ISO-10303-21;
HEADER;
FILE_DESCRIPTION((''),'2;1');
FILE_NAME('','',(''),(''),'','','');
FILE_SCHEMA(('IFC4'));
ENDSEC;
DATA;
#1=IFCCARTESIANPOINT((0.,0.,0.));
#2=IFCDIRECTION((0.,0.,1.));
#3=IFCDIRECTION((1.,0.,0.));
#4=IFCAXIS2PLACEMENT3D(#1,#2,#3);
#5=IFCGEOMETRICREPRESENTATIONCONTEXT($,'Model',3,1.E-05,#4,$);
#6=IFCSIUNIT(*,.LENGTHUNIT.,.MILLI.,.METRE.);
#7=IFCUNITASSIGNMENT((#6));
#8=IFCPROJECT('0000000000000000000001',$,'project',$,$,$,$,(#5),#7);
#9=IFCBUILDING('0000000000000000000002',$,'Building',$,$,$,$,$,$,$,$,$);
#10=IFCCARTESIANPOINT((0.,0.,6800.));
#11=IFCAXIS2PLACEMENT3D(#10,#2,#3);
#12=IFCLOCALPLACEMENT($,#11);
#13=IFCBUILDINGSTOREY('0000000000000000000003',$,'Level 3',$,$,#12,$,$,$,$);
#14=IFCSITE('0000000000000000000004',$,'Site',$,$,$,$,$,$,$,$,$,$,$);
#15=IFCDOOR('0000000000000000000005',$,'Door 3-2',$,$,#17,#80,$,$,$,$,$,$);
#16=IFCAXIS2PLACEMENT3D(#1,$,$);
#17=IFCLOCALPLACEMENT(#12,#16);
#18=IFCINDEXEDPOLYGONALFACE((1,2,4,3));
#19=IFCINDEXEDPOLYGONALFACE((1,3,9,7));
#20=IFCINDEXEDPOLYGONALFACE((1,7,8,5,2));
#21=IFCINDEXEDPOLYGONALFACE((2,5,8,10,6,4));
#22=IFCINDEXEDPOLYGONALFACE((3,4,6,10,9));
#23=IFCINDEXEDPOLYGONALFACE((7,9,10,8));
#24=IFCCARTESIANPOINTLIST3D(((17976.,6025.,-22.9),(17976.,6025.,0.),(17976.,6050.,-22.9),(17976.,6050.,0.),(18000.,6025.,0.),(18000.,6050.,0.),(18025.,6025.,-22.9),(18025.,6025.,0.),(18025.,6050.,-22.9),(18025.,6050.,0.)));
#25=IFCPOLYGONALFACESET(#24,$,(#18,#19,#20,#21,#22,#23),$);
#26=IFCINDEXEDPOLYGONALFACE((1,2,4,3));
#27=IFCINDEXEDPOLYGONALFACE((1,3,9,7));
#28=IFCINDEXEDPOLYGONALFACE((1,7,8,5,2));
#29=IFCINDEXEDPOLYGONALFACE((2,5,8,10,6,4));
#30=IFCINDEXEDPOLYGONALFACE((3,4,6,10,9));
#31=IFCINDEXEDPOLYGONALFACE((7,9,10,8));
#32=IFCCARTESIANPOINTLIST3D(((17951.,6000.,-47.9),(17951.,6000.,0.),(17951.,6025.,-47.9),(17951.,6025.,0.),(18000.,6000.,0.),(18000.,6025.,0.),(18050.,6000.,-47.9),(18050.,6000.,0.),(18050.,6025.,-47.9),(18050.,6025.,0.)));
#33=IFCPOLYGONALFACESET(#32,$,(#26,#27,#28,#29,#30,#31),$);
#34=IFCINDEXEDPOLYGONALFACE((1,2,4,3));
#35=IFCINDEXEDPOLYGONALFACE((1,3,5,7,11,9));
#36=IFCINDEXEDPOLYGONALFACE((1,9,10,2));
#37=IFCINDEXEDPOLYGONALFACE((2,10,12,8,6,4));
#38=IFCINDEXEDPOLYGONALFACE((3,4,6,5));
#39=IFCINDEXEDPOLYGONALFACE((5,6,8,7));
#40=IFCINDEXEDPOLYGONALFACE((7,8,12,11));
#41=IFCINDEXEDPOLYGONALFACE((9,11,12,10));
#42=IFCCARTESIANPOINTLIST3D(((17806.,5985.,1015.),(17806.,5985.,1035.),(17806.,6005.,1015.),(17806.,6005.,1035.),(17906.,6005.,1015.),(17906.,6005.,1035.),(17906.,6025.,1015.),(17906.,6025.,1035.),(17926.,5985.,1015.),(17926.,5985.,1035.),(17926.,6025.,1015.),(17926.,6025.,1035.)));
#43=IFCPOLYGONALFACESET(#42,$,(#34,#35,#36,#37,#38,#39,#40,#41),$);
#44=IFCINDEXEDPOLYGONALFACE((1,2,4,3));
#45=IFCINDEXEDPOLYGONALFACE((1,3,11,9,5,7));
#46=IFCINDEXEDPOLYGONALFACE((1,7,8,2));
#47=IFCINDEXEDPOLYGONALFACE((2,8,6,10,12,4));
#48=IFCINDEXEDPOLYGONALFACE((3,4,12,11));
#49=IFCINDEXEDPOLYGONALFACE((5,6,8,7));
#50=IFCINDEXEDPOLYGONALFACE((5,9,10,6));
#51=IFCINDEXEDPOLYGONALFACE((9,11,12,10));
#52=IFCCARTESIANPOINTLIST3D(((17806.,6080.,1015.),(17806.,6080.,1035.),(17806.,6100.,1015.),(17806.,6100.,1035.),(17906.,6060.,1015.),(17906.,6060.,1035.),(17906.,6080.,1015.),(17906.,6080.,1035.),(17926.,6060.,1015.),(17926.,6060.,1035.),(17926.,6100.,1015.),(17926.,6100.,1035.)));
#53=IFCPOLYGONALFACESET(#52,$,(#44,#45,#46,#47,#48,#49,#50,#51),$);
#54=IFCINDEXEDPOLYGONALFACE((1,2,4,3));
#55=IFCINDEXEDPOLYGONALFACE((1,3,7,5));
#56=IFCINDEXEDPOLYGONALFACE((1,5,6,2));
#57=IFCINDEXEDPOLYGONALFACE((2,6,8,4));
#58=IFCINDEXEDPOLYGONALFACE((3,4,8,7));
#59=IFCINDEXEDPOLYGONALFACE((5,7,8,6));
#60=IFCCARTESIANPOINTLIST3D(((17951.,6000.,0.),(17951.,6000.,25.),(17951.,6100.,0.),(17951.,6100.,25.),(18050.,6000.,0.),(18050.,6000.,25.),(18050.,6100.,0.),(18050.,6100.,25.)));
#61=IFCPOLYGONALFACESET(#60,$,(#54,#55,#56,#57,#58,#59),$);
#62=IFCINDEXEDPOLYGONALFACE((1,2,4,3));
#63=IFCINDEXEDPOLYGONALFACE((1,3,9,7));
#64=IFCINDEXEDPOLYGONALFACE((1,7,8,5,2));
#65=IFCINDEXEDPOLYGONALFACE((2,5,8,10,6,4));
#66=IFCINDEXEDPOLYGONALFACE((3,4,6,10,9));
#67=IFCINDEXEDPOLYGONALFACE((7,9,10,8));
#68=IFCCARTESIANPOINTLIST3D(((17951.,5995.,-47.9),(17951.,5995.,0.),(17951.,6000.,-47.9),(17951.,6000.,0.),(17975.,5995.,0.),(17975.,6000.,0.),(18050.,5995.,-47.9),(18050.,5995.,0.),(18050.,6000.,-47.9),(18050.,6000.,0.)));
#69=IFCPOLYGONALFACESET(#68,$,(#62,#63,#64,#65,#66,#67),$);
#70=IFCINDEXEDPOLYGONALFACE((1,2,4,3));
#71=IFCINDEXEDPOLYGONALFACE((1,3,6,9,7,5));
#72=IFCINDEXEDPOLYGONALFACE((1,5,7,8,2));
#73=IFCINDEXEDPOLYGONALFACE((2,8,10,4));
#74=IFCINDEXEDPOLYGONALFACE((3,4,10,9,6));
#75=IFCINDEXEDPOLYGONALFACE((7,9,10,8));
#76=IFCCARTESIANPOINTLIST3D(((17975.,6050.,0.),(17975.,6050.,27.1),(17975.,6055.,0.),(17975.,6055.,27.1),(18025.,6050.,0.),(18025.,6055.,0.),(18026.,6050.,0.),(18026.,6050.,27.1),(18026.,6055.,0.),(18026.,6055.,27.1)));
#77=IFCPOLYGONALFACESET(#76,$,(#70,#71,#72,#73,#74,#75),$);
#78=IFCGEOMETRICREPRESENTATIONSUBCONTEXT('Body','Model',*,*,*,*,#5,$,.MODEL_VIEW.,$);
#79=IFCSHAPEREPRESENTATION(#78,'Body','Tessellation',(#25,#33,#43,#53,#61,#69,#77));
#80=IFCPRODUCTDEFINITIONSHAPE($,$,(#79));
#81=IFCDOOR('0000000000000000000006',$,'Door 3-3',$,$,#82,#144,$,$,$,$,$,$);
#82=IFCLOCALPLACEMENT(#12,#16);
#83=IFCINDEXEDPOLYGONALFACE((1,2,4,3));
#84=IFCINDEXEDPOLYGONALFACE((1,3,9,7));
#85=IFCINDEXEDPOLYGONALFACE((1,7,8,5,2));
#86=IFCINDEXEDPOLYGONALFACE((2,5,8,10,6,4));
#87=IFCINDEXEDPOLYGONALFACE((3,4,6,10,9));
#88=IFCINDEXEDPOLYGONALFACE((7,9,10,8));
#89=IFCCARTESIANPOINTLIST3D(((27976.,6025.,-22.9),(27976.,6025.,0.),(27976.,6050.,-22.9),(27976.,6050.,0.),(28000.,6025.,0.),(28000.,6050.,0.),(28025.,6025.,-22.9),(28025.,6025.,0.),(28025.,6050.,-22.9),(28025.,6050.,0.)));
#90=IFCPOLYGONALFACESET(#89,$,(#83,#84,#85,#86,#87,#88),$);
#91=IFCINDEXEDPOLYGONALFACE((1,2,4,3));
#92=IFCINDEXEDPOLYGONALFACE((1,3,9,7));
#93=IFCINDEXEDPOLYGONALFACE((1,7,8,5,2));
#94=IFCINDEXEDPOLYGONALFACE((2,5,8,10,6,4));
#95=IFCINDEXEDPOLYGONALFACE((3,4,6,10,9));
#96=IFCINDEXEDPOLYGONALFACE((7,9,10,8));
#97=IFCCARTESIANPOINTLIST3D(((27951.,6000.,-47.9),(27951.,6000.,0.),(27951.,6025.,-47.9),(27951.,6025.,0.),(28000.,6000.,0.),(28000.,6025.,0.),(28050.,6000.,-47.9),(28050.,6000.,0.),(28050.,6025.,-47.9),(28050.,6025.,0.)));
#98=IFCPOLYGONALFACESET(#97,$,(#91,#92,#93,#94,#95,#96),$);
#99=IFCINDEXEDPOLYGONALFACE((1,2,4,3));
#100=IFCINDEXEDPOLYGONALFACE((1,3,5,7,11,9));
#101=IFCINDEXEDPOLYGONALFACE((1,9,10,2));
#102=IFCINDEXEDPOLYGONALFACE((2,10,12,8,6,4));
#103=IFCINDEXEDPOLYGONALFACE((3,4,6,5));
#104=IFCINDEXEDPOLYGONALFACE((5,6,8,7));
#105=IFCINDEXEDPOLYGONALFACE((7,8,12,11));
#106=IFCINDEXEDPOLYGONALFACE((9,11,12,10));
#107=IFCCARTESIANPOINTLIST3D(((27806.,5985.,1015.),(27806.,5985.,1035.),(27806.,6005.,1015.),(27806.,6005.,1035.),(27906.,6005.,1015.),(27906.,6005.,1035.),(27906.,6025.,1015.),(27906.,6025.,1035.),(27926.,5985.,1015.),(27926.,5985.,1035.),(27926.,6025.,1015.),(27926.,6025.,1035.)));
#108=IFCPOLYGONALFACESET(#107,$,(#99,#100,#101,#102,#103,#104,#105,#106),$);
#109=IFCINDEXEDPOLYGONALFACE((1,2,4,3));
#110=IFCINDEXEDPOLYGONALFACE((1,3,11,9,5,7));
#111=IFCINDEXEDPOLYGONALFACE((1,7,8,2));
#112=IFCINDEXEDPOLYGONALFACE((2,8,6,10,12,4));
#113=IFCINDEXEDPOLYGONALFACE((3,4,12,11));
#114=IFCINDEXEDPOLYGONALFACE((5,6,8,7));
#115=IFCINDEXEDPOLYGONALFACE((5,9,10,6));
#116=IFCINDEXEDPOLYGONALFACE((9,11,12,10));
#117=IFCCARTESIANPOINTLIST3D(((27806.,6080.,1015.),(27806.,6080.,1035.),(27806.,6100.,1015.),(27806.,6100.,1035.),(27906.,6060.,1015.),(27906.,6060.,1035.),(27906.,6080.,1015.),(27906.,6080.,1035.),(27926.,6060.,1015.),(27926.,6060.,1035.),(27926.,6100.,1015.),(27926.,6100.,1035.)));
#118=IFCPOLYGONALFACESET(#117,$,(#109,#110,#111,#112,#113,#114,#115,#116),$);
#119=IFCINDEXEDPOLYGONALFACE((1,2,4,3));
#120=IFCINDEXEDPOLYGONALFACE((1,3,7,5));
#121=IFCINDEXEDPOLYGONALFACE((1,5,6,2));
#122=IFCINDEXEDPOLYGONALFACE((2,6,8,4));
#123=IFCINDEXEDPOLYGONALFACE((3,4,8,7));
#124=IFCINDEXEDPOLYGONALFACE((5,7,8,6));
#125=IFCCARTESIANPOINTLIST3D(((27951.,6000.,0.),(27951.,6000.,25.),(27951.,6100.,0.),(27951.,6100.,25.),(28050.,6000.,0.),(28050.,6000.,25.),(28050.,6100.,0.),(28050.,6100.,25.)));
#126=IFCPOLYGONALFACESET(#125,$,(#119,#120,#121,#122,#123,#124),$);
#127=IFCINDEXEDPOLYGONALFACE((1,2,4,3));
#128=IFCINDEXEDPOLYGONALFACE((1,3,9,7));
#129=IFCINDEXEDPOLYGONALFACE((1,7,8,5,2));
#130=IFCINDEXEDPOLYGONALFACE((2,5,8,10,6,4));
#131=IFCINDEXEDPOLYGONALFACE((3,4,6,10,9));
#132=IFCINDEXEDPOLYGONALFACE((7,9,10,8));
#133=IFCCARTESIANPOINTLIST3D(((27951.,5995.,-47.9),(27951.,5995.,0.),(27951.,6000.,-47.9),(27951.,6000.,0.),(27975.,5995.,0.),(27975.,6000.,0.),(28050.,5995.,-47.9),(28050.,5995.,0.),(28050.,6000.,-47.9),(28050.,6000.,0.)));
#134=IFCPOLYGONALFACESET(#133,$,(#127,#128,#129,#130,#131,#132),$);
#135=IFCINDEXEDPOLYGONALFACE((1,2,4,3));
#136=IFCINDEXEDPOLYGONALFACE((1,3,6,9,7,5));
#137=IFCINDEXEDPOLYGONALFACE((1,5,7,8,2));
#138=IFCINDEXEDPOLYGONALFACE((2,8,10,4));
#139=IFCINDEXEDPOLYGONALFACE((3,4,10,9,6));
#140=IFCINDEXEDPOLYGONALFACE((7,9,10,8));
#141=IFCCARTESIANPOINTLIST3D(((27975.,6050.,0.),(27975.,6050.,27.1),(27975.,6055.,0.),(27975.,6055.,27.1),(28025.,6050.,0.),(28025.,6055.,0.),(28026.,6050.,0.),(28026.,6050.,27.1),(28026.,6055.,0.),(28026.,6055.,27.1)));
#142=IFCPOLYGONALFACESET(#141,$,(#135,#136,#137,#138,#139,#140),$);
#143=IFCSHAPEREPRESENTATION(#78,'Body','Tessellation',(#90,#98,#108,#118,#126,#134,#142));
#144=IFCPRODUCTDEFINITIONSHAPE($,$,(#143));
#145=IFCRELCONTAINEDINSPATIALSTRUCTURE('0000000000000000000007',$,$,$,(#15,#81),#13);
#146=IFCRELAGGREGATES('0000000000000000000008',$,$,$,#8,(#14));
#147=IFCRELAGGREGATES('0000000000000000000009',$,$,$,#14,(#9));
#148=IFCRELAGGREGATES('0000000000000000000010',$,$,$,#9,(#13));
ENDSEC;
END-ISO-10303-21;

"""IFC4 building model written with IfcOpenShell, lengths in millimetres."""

from ifc_helpers import new_model, si_unit, frame, origin_with_axes, place, context, subcontext, project, spatial, line, indexed_curve, outline, extrude, element, save


model = new_model("IFC4")

# Units and contexts
model_context = context("Model", 3, precision=1e-05, world=origin_with_axes())
body_context = subcontext(model_context, "Body", "Model", "MODEL_VIEW")
ifc_project = project(units=[si_unit("LENGTHUNIT", "METRE", prefix="MILLI")], contexts=[model_context])

# Site, building, storey
site = spatial("IfcSite", under=ifc_project, Name="Site")
building = spatial("IfcBuilding", under=site, Name="Building")
storey_placement = place(None, frame((0.0, 0.0, 6800.0), z_axis=(0.0, 0.0, 1.0), x_axis=(1.0, 0.0, 0.0)))
storey = spatial("IfcBuildingStorey", under=building, at=storey_placement, Name="Level 3")

# Doors
door_1_placement = place(storey_placement, frame((18000.0, 6000.0, 0.0), z_axis=(0.0, 0.0, 1.0), x_axis=(1.0, 0.0, 0.0)))
element("IfcDoor", 1, at=door_1_placement, inside=storey, Name="Door 3-2", context=body_context, shape_type="SweptSolid", body=[
    extrude(outline(indexed_curve([(0.0, 0.0), (0.0, 2.1), (1.0, 2.1), (1.0, 0.0), (-24.0, 0.0), (-24.0, -22.9), (25.0, -22.9), (25.0, 0.0)], segments=[line(1, 2, 3, 4, 5, 6, 7, 8, 1)])), frame((0.0, 25.0, 0.0), z_axis=(0.0, -1.0, 0.0), x_axis=(1.0, 0.0, 0.0)), (0.0, 0.0, -1.0), 25.0),
    extrude(outline(indexed_curve([(0.0, 0.0), (0.0, 2.1), (1.0, 2.1), (1.0, 0.0), (-49.0, 0.0), (-49.0, -47.9), (50.0, -47.9), (50.0, 0.0)], segments=[line(1, 2, 3, 4, 5, 6, 7, 8, 1)])), frame((0.0, 0.0, 0.0), z_axis=(0.0, -1.0, 0.0), x_axis=(1.0, 0.0, 0.0)), (0.0, 0.0, -1.0), 25.0),
    extrude(outline(indexed_curve([(0.0, 0.0), (-49.0, 0.0), (-49.0, 35.0), (0.0, 35.0)], segments=[line(1, 2, 3, 4, 1)])), frame((25.0, 25.0, 25.0), z_axis=(0.0, 0.0, 1.0), x_axis=(1.0, 0.0, 0.0)), (0.0, 0.0, 1.0), -47.9),
    extrude(outline(indexed_curve([(0.0, 0.0), (0.0, -40.0), (-120.0, -40.0), (-120.0, -20.0), (-20.0, -20.0), (-20.0, 0.0)], segments=[line(1, 2, 3, 4, 5, 6, 1)])), frame((-74.0, 25.0, 1015.0), z_axis=(0.0, 0.0, 1.0), x_axis=(1.0, 0.0, 0.0)), (0.0, 0.0, 1.0), 20.0),
    extrude(outline(indexed_curve([(0.0, 0.0), (0.0, 40.0), (-120.0, 40.0), (-120.0, 20.0), (-20.0, 20.0), (-20.0, 0.0)], segments=[line(1, 2, 3, 4, 5, 6, 1)])), frame((-74.0, 60.0, 1015.0), z_axis=(0.0, 0.0, 1.0), x_axis=(1.0, 0.0, 0.0)), (0.0, 0.0, 1.0), 20.0),
    extrude(outline(indexed_curve([(0.0, 0.0), (-99.0, 0.0), (-99.0, 100.0), (0.0, 100.0)], segments=[line(1, 2, 3, 4, 1)])), frame((50.0, 0.0, 0.0), z_axis=(0.0, 0.0, 1.0), x_axis=(1.0, 0.0, 0.0)), (0.0, 0.0, 1.0), 25.0),
    extrude(outline(indexed_curve([(0.0, 0.0), (0.0, 27.1), (51.0, 27.1), (51.0, 0.0), (-24.0, 0.0), (-24.0, -47.9), (75.0, -47.9), (75.0, 0.0)], segments=[line(1, 2, 3, 4, 5, 6, 7, 8, 1)])), frame((-25.0, -5.0, 0.0), z_axis=(0.0, -1.0, 0.0), x_axis=(1.0, 0.0, 0.0)), (0.0, 0.0, -1.0), 5.0),
    extrude(outline(indexed_curve([(0.0, 0.0), (0.0, 27.1), (51.0, 27.1), (51.0, 0.0), (1.0, 0.0), (1.0, -22.9), (50.0, -22.9), (50.0, 0.0)], segments=[line(1, 2, 3, 4, 5, 6, 7, 8, 1)])), frame((-25.0, 50.0, 0.0), z_axis=(0.0, -1.0, 0.0), x_axis=(1.0, 0.0, 0.0)), (0.0, 0.0, -1.0), 5.0),
])
door_2_placement = place(storey_placement, frame((28000.0, 6000.0, 0.0), z_axis=(0.0, 0.0, 1.0), x_axis=(1.0, 0.0, 0.0)))
element("IfcDoor", 2, at=door_2_placement, inside=storey, Name="Door 3-3", context=body_context, shape_type="SweptSolid", body=[
    extrude(outline(indexed_curve([(0.0, 0.0), (0.0, 2.1), (1.0, 2.1), (1.0, 0.0), (-24.0, 0.0), (-24.0, -22.9), (25.0, -22.9), (25.0, 0.0)], segments=[line(1, 2, 3, 4, 5, 6, 7, 8, 1)])), frame((0.0, 25.0, 0.0), z_axis=(0.0, -1.0, 0.0), x_axis=(1.0, 0.0, 0.0)), (0.0, 0.0, -1.0), 25.0),
    extrude(outline(indexed_curve([(0.0, 0.0), (0.0, 2.1), (1.0, 2.1), (1.0, 0.0), (-49.0, 0.0), (-49.0, -47.9), (50.0, -47.9), (50.0, 0.0)], segments=[line(1, 2, 3, 4, 5, 6, 7, 8, 1)])), frame((0.0, 0.0, 0.0), z_axis=(0.0, -1.0, 0.0), x_axis=(1.0, 0.0, 0.0)), (0.0, 0.0, -1.0), 25.0),
    extrude(outline(indexed_curve([(0.0, 0.0), (-49.0, 0.0), (-49.0, 35.0), (0.0, 35.0)], segments=[line(1, 2, 3, 4, 1)])), frame((25.0, 25.0, 25.0), z_axis=(0.0, 0.0, 1.0), x_axis=(1.0, 0.0, 0.0)), (0.0, 0.0, 1.0), -47.9),
    extrude(outline(indexed_curve([(0.0, 0.0), (0.0, -40.0), (-120.0, -40.0), (-120.0, -20.0), (-20.0, -20.0), (-20.0, 0.0)], segments=[line(1, 2, 3, 4, 5, 6, 1)])), frame((-74.0, 25.0, 1015.0), z_axis=(0.0, 0.0, 1.0), x_axis=(1.0, 0.0, 0.0)), (0.0, 0.0, 1.0), 20.0),
    extrude(outline(indexed_curve([(0.0, 0.0), (0.0, 40.0), (-120.0, 40.0), (-120.0, 20.0), (-20.0, 20.0), (-20.0, 0.0)], segments=[line(1, 2, 3, 4, 5, 6, 1)])), frame((-74.0, 60.0, 1015.0), z_axis=(0.0, 0.0, 1.0), x_axis=(1.0, 0.0, 0.0)), (0.0, 0.0, 1.0), 20.0),
    extrude(outline(indexed_curve([(0.0, 0.0), (-99.0, 0.0), (-99.0, 100.0), (0.0, 100.0)], segments=[line(1, 2, 3, 4, 1)])), frame((50.0, 0.0, 0.0), z_axis=(0.0, 0.0, 1.0), x_axis=(1.0, 0.0, 0.0)), (0.0, 0.0, 1.0), 25.0),
    extrude(outline(indexed_curve([(0.0, 0.0), (0.0, 27.1), (51.0, 27.1), (51.0, 0.0), (-24.0, 0.0), (-24.0, -47.9), (75.0, -47.9), (75.0, 0.0)], segments=[line(1, 2, 3, 4, 5, 6, 7, 8, 1)])), frame((-25.0, -5.0, 0.0), z_axis=(0.0, -1.0, 0.0), x_axis=(1.0, 0.0, 0.0)), (0.0, 0.0, -1.0), 5.0),
    extrude(outline(indexed_curve([(0.0, 0.0), (0.0, 27.1), (51.0, 27.1), (51.0, 0.0), (1.0, 0.0), (1.0, -22.9), (50.0, -22.9), (50.0, 0.0)], segments=[line(1, 2, 3, 4, 5, 6, 7, 8, 1)])), frame((-25.0, 50.0, 0.0), z_axis=(0.0, -1.0, 0.0), x_axis=(1.0, 0.0, 0.0)), (0.0, 0.0, -1.0), 5.0),
])

save(model, "model.ifc")
